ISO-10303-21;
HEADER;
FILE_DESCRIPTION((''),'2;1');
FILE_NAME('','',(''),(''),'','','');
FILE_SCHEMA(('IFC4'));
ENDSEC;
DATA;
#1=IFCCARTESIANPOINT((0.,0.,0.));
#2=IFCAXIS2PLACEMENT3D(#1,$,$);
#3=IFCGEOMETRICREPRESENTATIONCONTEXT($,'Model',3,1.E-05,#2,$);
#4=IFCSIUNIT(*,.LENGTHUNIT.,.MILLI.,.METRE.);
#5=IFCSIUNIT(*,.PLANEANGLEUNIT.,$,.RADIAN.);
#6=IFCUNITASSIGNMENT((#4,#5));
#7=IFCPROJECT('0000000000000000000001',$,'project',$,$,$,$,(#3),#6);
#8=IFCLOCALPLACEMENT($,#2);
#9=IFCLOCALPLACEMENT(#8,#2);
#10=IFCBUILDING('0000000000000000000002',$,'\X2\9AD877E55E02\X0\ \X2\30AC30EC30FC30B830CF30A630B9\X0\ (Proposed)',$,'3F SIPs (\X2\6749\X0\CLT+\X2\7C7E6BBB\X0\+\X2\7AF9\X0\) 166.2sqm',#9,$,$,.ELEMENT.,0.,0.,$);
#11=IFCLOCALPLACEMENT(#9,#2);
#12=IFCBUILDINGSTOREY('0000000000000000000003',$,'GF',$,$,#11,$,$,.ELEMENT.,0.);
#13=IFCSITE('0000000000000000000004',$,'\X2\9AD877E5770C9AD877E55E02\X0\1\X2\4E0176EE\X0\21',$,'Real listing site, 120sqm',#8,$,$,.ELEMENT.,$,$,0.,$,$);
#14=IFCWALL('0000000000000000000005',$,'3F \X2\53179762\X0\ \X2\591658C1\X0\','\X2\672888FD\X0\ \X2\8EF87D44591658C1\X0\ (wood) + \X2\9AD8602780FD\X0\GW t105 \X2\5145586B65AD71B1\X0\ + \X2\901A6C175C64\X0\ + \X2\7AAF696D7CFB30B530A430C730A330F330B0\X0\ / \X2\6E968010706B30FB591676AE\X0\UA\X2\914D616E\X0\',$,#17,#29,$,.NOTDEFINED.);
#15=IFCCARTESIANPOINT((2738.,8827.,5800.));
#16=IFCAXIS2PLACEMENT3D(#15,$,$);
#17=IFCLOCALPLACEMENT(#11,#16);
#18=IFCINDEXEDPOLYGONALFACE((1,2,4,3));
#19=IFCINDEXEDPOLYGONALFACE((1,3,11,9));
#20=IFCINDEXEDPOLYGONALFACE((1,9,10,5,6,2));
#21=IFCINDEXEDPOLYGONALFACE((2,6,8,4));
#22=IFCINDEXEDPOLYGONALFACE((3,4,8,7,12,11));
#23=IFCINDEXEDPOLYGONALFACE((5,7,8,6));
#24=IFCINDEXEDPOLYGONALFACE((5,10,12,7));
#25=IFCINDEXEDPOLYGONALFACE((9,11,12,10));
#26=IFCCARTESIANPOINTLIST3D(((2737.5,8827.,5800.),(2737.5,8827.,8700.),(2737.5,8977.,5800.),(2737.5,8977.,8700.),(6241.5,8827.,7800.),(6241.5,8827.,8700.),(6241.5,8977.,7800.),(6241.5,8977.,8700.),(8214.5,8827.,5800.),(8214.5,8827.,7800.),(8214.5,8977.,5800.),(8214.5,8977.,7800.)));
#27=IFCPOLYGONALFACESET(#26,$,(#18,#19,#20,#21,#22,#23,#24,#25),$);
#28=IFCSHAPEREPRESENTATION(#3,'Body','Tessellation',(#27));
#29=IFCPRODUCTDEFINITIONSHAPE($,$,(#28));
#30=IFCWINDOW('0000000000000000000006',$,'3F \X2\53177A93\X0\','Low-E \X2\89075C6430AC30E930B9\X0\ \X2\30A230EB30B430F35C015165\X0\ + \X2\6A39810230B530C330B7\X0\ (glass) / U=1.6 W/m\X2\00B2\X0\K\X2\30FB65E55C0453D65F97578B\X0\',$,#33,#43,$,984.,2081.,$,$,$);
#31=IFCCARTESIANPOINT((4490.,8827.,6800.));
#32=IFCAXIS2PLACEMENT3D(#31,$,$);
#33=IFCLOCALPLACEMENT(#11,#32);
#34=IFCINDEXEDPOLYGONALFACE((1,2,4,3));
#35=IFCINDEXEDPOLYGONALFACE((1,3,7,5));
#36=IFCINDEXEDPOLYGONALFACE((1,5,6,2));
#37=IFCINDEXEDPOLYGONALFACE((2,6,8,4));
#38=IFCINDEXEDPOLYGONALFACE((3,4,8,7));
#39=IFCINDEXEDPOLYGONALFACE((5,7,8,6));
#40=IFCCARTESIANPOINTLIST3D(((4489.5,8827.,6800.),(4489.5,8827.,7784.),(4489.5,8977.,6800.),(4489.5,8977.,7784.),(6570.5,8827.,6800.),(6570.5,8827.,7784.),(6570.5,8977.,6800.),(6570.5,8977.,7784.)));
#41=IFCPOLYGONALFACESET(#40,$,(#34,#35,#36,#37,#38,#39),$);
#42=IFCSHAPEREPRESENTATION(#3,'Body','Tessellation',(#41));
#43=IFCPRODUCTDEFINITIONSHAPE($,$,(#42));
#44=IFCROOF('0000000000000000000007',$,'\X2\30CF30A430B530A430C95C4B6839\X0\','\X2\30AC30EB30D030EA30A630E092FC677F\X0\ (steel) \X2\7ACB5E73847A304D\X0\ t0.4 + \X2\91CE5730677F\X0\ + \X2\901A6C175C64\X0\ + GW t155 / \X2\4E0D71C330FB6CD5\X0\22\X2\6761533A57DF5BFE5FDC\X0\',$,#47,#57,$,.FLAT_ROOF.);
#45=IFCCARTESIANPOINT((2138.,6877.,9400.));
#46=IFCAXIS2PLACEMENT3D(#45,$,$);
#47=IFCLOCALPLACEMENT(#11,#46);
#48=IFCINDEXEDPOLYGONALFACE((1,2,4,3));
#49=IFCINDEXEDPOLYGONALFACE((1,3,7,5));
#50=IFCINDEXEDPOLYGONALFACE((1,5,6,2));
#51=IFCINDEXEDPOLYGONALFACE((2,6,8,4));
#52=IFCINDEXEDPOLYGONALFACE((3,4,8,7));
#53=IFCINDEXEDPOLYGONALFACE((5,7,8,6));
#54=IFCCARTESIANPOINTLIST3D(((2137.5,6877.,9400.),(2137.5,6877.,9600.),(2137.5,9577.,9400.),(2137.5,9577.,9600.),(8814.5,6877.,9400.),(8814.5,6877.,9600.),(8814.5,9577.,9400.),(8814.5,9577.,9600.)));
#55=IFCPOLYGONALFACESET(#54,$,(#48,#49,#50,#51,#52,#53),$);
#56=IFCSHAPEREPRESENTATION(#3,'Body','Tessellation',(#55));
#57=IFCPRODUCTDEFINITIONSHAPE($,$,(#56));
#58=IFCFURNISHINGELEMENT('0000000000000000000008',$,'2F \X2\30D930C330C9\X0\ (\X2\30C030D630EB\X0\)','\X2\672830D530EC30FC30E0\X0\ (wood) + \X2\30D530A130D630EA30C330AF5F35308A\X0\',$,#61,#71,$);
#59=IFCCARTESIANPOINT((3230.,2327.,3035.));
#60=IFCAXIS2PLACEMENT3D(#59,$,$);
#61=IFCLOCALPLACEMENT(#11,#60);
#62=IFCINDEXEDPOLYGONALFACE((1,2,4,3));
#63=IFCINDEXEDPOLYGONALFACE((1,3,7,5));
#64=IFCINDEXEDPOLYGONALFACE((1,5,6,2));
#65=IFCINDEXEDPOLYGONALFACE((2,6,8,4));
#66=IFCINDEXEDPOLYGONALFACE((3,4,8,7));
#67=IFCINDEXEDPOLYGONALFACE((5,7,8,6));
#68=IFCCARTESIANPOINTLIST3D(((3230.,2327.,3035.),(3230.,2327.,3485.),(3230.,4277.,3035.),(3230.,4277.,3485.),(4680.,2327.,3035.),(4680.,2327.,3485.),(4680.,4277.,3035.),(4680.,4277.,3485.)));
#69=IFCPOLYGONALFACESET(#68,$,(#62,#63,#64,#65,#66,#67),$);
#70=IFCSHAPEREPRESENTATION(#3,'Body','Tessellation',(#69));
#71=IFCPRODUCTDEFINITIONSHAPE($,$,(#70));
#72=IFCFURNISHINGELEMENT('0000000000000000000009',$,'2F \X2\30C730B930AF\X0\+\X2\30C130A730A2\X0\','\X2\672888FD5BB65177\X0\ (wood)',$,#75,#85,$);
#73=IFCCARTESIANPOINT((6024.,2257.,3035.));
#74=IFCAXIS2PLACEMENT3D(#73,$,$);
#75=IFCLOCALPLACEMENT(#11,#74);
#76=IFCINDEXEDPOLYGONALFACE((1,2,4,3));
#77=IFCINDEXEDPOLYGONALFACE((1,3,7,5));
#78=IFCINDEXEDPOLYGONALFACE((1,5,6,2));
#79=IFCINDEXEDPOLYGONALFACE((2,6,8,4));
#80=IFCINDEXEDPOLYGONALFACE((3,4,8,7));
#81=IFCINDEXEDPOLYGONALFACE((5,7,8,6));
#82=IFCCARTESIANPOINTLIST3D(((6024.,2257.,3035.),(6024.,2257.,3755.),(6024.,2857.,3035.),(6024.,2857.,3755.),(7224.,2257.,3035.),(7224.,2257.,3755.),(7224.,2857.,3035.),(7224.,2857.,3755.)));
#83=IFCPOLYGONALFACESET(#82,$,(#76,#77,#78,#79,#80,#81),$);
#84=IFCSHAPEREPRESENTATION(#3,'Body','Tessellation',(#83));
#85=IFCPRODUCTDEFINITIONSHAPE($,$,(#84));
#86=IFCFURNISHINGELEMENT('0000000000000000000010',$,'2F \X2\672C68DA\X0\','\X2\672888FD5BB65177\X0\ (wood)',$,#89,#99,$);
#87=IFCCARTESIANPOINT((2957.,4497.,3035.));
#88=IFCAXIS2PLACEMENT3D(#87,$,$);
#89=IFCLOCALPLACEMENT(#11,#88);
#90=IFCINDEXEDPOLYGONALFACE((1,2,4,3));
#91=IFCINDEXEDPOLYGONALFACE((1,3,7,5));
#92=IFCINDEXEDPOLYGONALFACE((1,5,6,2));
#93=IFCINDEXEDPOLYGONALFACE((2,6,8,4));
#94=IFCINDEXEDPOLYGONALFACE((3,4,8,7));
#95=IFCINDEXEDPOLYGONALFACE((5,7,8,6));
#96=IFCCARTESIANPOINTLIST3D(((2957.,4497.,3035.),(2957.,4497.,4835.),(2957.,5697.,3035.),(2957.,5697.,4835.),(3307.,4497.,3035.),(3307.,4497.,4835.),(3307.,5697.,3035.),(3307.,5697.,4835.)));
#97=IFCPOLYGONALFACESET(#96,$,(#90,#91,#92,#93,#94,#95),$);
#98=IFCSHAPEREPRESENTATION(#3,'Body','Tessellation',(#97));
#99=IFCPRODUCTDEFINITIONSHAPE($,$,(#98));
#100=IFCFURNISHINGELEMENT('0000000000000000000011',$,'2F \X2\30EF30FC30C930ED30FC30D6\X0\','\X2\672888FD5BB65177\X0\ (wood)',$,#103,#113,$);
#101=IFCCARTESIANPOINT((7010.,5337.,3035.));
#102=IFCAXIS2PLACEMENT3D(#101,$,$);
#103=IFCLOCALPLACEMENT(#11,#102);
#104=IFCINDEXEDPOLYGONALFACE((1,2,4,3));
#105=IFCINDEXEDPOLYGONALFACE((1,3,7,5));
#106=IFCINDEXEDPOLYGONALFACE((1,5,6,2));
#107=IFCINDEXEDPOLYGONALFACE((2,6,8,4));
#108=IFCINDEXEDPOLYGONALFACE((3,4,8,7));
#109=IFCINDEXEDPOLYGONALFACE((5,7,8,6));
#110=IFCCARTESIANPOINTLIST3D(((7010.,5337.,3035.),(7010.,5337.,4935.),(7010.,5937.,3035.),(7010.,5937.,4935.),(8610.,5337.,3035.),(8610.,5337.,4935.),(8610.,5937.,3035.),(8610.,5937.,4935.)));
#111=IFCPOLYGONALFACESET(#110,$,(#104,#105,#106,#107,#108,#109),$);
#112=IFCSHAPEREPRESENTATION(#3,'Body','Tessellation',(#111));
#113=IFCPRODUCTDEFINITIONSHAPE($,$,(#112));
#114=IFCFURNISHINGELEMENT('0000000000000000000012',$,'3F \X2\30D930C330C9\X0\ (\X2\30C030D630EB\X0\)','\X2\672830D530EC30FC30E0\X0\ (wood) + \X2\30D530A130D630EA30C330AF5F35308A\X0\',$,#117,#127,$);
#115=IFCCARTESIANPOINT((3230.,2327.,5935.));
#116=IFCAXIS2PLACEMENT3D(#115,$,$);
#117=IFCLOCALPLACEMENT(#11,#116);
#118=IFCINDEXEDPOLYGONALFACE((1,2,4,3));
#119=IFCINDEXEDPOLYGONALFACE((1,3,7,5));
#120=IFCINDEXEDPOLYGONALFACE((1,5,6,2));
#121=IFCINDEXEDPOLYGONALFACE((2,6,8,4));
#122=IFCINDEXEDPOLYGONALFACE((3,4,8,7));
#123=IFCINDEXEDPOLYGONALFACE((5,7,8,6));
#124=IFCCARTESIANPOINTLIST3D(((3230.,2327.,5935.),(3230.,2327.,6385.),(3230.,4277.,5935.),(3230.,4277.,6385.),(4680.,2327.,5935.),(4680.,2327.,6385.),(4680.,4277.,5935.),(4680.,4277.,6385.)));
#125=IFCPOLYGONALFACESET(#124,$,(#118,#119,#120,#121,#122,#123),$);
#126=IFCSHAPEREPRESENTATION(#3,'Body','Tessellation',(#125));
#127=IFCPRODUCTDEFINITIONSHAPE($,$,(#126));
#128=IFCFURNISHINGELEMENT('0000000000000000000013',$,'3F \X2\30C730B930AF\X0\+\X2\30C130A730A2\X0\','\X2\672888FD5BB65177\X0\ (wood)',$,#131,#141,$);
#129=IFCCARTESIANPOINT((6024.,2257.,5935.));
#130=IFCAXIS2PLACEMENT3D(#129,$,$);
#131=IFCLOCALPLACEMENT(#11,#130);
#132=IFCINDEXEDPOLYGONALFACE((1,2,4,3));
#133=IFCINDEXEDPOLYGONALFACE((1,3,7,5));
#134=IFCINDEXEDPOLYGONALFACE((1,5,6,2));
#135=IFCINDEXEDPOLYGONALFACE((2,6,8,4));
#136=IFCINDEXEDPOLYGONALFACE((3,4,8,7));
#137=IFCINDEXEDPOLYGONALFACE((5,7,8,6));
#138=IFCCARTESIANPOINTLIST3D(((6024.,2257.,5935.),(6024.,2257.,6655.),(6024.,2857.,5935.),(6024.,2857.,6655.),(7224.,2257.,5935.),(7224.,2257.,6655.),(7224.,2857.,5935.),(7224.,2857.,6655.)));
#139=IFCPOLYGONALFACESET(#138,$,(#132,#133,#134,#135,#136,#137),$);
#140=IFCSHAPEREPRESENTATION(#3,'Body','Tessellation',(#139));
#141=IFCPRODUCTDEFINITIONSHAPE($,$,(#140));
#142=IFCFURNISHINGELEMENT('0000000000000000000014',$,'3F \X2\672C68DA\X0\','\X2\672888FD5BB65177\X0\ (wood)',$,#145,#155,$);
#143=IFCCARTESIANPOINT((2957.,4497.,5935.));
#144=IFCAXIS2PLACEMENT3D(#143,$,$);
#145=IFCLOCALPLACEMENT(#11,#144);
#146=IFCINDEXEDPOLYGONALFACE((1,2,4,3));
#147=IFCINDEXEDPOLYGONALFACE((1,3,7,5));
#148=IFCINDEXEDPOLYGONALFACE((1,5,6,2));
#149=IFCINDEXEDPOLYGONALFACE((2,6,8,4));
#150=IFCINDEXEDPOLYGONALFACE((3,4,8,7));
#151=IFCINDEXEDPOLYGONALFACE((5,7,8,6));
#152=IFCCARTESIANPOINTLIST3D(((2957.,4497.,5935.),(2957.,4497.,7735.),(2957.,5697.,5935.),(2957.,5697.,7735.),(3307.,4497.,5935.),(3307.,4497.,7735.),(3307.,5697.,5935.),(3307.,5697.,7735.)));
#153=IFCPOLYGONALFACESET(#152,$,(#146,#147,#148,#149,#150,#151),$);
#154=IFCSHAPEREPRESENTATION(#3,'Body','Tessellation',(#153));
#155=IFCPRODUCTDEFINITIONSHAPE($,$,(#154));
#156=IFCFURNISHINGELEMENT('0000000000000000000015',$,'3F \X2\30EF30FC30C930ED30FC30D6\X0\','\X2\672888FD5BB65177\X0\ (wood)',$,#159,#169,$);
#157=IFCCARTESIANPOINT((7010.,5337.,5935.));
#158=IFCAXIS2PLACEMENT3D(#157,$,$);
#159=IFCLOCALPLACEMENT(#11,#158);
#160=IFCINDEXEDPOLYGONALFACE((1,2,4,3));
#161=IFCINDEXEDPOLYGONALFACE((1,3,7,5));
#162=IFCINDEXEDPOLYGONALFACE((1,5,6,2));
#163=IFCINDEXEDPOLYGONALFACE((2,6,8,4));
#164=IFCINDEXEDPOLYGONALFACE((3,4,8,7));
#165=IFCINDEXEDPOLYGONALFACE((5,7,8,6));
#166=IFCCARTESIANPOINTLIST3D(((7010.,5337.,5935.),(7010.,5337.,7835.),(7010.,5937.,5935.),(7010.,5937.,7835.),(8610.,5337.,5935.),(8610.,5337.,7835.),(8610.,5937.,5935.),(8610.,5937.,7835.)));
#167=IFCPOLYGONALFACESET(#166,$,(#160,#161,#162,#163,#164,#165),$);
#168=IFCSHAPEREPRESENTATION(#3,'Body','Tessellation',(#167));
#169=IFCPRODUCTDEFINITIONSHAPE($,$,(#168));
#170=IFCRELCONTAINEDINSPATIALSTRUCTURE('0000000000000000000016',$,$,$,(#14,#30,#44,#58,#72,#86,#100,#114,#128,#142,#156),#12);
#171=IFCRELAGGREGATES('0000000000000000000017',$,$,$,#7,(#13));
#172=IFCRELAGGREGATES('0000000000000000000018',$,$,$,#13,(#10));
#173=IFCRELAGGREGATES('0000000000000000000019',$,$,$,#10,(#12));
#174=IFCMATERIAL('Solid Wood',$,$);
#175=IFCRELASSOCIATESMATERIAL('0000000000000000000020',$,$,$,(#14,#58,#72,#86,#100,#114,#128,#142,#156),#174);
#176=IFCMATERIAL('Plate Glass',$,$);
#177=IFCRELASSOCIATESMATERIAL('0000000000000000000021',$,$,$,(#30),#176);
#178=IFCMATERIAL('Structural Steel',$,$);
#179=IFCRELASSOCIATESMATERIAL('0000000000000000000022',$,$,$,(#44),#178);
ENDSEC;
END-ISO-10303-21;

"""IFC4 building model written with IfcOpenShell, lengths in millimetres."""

from ifc_helpers import new_model, si_unit, frame, frame_2d, origin, place, context, project, spatial, rectangle, extrude, material, element, fill, save


model = new_model("IFC4")

# Units and contexts
model_context = context("Model", 3, precision=1e-05, world=origin())
ifc_project = project(units=[si_unit("LENGTHUNIT", "METRE", prefix="MILLI"), si_unit("PLANEANGLEUNIT", "RADIAN")], contexts=[model_context])

# Site, building, storey
site_placement = place(None, origin())
site = spatial("IfcSite", under=ifc_project, at=site_placement, Name="高知県高知市1丁目21", ObjectType="Real listing site, 120sqm", CompositionType="ELEMENT", RefElevation=0.0)
building_placement = place(site_placement, origin())
building = spatial("IfcBuilding", under=site, at=building_placement, Name="高知市 ガレージハウス (Proposed)", ObjectType="3F SIPs (杉CLT+籾殻+竹) 166.2sqm", CompositionType="ELEMENT", ElevationOfRefHeight=0.0, ElevationOfTerrain=0.0)
storey_placement = place(building_placement, origin())
storey = spatial("IfcBuildingStorey", under=building, at=storey_placement, Name="GF", CompositionType="ELEMENT", Elevation=0.0)

# Shared definitions
ifc_material_1 = material(Name="Solid Wood")

# Wall, opening, window
wall_1_placement = place(storey_placement, frame((2738.0, 8827.0, 5800.0)))
wall_1 = element("IfcWall", 1, at=wall_1_placement, inside=storey, material=ifc_material_1, Name="3F 北面 外壁", Description="木製 軸組外壁 (wood) + 高性能GW t105 充填断熱 + 通気層 + 窯業系サイディング / 準耐火・外皮UA配慮", PredefinedType="NOTDEFINED", context=model_context, shape_type="SweptSolid", body=[
    extrude(rectangle(XDim=5477.0, YDim=150.0, at=frame_2d((2738.0, 75.0))), frame((2738.0, 8827.0, 5800.0)), (0.0, 0.0, 1.0), 2900.0),
])
opening_1_placement = place(storey_placement, frame((4490.0, 8827.0, 6800.0)))
opening_1 = element("IfcOpeningElement", 2, at=opening_1_placement, cuts=wall_1, PredefinedType="NOTDEFINED", context=model_context, shape_type="SweptSolid", body=[
    extrude(rectangle(XDim=2081.0, YDim=150.0, at=frame_2d((1040.0, 75.0))), frame((4490.0, 8827.0, 6800.0)), (0.0, 0.0, 1.0), 984.0),
])
ifc_material_2 = material(Name="Plate Glass")
window_1_placement = place(storey_placement, frame((4490.0, 8827.0, 6800.0)))
window_1 = element("IfcWindow", 3, at=window_1_placement, inside=storey, material=ifc_material_2, Name="3F 北窓", Description="Low-E 複層ガラス アルゴン封入 + 樹脂サッシ (glass) / U=1.6 W/m²K・日射取得型", OverallHeight=984.0, OverallWidth=2081.0, context=model_context, shape_type="SweptSolid", body=[
    extrude(rectangle(XDim=2081.0, YDim=150.0, at=frame_2d((1040.0, 75.0))), frame((4490.0, 8827.0, 6800.0)), (0.0, 0.0, 1.0), 984.0),
])
fill(opening_1, window_1)

# Roof
ifc_material_3 = material(Name="Structural Steel")
roof_placement = place(storey_placement, frame((2138.0, 6877.0, 9400.0)))
element("IfcRoof", 4, at=roof_placement, inside=storey, material=ifc_material_3, Name="ハイサイド屋根", Description="ガルバリウム鋼板 (steel) 立平葺き t0.4 + 野地板 + 通気層 + GW t155 / 不燃・法22条区域対応", PredefinedType="FLAT_ROOF", context=model_context, shape_type="SweptSolid", body=[
    extrude(rectangle(XDim=6677.0, YDim=2700.0, at=frame_2d((3338.0, 1350.0))), frame((2138.0, 6877.0, 9400.0)), (0.0, 0.0, 1.0), 200.0),
])

# Furnishing elements
furnishing_1_placement = place(storey_placement, frame((3230.0, 2327.0, 3035.0)))
element("IfcFurnishingElement", 5, at=furnishing_1_placement, inside=storey, material=ifc_material_1, Name="2F ベッド (ダブル)", Description="木フレーム (wood) + ファブリック張り", context=model_context, shape_type="SweptSolid", body=[
    extrude(rectangle(XDim=1450.0, YDim=1950.0, at=frame_2d((725.0, 975.0))), frame((3230.0, 2327.0, 3035.0)), (0.0, 0.0, 1.0), 450.0),
])
furnishing_2_placement = place(storey_placement, frame((6024.0, 2257.0, 3035.0)))
element("IfcFurnishingElement", 6, at=furnishing_2_placement, inside=storey, material=ifc_material_1, Name="2F デスク+チェア", Description="木製家具 (wood)", context=model_context, shape_type="SweptSolid", body=[
    extrude(rectangle(XDim=1200.0, YDim=600.0, at=frame_2d((600.0, 300.0))), frame((6024.0, 2257.0, 3035.0)), (0.0, 0.0, 1.0), 720.0),
])
furnishing_3_placement = place(storey_placement, frame((2957.0, 4497.0, 3035.0)))
element("IfcFurnishingElement", 7, at=furnishing_3_placement, inside=storey, material=ifc_material_1, Name="2F 本棚", Description="木製家具 (wood)", context=model_context, shape_type="SweptSolid", body=[
    extrude(rectangle(XDim=350.0, YDim=1200.0, at=frame_2d((175.0, 600.0))), frame((2957.0, 4497.0, 3035.0)), (0.0, 0.0, 1.0), 1800.0),
])
furnishing_4_placement = place(storey_placement, frame((7010.0, 5337.0, 3035.0)))
element("IfcFurnishingElement", 8, at=furnishing_4_placement, inside=storey, material=ifc_material_1, Name="2F ワードローブ", Description="木製家具 (wood)", context=model_context, shape_type="SweptSolid", body=[
    extrude(rectangle(XDim=1600.0, YDim=600.0, at=frame_2d((800.0, 300.0))), frame((7010.0, 5337.0, 3035.0)), (0.0, 0.0, 1.0), 1900.0),
])
furnishing_5_placement = place(storey_placement, frame((3230.0, 2327.0, 5935.0)))
element("IfcFurnishingElement", 9, at=furnishing_5_placement, inside=storey, material=ifc_material_1, Name="3F ベッド (ダブル)", Description="木フレーム (wood) + ファブリック張り", context=model_context, shape_type="SweptSolid", body=[
    extrude(rectangle(XDim=1450.0, YDim=1950.0, at=frame_2d((725.0, 975.0))), frame((3230.0, 2327.0, 5935.0)), (0.0, 0.0, 1.0), 450.0),
])
furnishing_6_placement = place(storey_placement, frame((6024.0, 2257.0, 5935.0)))
element("IfcFurnishingElement", 10, at=furnishing_6_placement, inside=storey, material=ifc_material_1, Name="3F デスク+チェア", Description="木製家具 (wood)", context=model_context, shape_type="SweptSolid", body=[
    extrude(rectangle(XDim=1200.0, YDim=600.0, at=frame_2d((600.0, 300.0))), frame((6024.0, 2257.0, 5935.0)), (0.0, 0.0, 1.0), 720.0),
])
furnishing_7_placement = place(storey_placement, frame((2957.0, 4497.0, 5935.0)))
element("IfcFurnishingElement", 11, at=furnishing_7_placement, inside=storey, material=ifc_material_1, Name="3F 本棚", Description="木製家具 (wood)", context=model_context, shape_type="SweptSolid", body=[
    extrude(rectangle(XDim=350.0, YDim=1200.0, at=frame_2d((175.0, 600.0))), frame((2957.0, 4497.0, 5935.0)), (0.0, 0.0, 1.0), 1800.0),
])
furnishing_8_placement = place(storey_placement, frame((7010.0, 5337.0, 5935.0)))
element("IfcFurnishingElement", 12, at=furnishing_8_placement, inside=storey, material=ifc_material_1, Name="3F ワードローブ", Description="木製家具 (wood)", context=model_context, shape_type="SweptSolid", body=[
    extrude(rectangle(XDim=1600.0, YDim=600.0, at=frame_2d((800.0, 300.0))), frame((7010.0, 5337.0, 5935.0)), (0.0, 0.0, 1.0), 1900.0),
])

save(model, "model.ifc")
